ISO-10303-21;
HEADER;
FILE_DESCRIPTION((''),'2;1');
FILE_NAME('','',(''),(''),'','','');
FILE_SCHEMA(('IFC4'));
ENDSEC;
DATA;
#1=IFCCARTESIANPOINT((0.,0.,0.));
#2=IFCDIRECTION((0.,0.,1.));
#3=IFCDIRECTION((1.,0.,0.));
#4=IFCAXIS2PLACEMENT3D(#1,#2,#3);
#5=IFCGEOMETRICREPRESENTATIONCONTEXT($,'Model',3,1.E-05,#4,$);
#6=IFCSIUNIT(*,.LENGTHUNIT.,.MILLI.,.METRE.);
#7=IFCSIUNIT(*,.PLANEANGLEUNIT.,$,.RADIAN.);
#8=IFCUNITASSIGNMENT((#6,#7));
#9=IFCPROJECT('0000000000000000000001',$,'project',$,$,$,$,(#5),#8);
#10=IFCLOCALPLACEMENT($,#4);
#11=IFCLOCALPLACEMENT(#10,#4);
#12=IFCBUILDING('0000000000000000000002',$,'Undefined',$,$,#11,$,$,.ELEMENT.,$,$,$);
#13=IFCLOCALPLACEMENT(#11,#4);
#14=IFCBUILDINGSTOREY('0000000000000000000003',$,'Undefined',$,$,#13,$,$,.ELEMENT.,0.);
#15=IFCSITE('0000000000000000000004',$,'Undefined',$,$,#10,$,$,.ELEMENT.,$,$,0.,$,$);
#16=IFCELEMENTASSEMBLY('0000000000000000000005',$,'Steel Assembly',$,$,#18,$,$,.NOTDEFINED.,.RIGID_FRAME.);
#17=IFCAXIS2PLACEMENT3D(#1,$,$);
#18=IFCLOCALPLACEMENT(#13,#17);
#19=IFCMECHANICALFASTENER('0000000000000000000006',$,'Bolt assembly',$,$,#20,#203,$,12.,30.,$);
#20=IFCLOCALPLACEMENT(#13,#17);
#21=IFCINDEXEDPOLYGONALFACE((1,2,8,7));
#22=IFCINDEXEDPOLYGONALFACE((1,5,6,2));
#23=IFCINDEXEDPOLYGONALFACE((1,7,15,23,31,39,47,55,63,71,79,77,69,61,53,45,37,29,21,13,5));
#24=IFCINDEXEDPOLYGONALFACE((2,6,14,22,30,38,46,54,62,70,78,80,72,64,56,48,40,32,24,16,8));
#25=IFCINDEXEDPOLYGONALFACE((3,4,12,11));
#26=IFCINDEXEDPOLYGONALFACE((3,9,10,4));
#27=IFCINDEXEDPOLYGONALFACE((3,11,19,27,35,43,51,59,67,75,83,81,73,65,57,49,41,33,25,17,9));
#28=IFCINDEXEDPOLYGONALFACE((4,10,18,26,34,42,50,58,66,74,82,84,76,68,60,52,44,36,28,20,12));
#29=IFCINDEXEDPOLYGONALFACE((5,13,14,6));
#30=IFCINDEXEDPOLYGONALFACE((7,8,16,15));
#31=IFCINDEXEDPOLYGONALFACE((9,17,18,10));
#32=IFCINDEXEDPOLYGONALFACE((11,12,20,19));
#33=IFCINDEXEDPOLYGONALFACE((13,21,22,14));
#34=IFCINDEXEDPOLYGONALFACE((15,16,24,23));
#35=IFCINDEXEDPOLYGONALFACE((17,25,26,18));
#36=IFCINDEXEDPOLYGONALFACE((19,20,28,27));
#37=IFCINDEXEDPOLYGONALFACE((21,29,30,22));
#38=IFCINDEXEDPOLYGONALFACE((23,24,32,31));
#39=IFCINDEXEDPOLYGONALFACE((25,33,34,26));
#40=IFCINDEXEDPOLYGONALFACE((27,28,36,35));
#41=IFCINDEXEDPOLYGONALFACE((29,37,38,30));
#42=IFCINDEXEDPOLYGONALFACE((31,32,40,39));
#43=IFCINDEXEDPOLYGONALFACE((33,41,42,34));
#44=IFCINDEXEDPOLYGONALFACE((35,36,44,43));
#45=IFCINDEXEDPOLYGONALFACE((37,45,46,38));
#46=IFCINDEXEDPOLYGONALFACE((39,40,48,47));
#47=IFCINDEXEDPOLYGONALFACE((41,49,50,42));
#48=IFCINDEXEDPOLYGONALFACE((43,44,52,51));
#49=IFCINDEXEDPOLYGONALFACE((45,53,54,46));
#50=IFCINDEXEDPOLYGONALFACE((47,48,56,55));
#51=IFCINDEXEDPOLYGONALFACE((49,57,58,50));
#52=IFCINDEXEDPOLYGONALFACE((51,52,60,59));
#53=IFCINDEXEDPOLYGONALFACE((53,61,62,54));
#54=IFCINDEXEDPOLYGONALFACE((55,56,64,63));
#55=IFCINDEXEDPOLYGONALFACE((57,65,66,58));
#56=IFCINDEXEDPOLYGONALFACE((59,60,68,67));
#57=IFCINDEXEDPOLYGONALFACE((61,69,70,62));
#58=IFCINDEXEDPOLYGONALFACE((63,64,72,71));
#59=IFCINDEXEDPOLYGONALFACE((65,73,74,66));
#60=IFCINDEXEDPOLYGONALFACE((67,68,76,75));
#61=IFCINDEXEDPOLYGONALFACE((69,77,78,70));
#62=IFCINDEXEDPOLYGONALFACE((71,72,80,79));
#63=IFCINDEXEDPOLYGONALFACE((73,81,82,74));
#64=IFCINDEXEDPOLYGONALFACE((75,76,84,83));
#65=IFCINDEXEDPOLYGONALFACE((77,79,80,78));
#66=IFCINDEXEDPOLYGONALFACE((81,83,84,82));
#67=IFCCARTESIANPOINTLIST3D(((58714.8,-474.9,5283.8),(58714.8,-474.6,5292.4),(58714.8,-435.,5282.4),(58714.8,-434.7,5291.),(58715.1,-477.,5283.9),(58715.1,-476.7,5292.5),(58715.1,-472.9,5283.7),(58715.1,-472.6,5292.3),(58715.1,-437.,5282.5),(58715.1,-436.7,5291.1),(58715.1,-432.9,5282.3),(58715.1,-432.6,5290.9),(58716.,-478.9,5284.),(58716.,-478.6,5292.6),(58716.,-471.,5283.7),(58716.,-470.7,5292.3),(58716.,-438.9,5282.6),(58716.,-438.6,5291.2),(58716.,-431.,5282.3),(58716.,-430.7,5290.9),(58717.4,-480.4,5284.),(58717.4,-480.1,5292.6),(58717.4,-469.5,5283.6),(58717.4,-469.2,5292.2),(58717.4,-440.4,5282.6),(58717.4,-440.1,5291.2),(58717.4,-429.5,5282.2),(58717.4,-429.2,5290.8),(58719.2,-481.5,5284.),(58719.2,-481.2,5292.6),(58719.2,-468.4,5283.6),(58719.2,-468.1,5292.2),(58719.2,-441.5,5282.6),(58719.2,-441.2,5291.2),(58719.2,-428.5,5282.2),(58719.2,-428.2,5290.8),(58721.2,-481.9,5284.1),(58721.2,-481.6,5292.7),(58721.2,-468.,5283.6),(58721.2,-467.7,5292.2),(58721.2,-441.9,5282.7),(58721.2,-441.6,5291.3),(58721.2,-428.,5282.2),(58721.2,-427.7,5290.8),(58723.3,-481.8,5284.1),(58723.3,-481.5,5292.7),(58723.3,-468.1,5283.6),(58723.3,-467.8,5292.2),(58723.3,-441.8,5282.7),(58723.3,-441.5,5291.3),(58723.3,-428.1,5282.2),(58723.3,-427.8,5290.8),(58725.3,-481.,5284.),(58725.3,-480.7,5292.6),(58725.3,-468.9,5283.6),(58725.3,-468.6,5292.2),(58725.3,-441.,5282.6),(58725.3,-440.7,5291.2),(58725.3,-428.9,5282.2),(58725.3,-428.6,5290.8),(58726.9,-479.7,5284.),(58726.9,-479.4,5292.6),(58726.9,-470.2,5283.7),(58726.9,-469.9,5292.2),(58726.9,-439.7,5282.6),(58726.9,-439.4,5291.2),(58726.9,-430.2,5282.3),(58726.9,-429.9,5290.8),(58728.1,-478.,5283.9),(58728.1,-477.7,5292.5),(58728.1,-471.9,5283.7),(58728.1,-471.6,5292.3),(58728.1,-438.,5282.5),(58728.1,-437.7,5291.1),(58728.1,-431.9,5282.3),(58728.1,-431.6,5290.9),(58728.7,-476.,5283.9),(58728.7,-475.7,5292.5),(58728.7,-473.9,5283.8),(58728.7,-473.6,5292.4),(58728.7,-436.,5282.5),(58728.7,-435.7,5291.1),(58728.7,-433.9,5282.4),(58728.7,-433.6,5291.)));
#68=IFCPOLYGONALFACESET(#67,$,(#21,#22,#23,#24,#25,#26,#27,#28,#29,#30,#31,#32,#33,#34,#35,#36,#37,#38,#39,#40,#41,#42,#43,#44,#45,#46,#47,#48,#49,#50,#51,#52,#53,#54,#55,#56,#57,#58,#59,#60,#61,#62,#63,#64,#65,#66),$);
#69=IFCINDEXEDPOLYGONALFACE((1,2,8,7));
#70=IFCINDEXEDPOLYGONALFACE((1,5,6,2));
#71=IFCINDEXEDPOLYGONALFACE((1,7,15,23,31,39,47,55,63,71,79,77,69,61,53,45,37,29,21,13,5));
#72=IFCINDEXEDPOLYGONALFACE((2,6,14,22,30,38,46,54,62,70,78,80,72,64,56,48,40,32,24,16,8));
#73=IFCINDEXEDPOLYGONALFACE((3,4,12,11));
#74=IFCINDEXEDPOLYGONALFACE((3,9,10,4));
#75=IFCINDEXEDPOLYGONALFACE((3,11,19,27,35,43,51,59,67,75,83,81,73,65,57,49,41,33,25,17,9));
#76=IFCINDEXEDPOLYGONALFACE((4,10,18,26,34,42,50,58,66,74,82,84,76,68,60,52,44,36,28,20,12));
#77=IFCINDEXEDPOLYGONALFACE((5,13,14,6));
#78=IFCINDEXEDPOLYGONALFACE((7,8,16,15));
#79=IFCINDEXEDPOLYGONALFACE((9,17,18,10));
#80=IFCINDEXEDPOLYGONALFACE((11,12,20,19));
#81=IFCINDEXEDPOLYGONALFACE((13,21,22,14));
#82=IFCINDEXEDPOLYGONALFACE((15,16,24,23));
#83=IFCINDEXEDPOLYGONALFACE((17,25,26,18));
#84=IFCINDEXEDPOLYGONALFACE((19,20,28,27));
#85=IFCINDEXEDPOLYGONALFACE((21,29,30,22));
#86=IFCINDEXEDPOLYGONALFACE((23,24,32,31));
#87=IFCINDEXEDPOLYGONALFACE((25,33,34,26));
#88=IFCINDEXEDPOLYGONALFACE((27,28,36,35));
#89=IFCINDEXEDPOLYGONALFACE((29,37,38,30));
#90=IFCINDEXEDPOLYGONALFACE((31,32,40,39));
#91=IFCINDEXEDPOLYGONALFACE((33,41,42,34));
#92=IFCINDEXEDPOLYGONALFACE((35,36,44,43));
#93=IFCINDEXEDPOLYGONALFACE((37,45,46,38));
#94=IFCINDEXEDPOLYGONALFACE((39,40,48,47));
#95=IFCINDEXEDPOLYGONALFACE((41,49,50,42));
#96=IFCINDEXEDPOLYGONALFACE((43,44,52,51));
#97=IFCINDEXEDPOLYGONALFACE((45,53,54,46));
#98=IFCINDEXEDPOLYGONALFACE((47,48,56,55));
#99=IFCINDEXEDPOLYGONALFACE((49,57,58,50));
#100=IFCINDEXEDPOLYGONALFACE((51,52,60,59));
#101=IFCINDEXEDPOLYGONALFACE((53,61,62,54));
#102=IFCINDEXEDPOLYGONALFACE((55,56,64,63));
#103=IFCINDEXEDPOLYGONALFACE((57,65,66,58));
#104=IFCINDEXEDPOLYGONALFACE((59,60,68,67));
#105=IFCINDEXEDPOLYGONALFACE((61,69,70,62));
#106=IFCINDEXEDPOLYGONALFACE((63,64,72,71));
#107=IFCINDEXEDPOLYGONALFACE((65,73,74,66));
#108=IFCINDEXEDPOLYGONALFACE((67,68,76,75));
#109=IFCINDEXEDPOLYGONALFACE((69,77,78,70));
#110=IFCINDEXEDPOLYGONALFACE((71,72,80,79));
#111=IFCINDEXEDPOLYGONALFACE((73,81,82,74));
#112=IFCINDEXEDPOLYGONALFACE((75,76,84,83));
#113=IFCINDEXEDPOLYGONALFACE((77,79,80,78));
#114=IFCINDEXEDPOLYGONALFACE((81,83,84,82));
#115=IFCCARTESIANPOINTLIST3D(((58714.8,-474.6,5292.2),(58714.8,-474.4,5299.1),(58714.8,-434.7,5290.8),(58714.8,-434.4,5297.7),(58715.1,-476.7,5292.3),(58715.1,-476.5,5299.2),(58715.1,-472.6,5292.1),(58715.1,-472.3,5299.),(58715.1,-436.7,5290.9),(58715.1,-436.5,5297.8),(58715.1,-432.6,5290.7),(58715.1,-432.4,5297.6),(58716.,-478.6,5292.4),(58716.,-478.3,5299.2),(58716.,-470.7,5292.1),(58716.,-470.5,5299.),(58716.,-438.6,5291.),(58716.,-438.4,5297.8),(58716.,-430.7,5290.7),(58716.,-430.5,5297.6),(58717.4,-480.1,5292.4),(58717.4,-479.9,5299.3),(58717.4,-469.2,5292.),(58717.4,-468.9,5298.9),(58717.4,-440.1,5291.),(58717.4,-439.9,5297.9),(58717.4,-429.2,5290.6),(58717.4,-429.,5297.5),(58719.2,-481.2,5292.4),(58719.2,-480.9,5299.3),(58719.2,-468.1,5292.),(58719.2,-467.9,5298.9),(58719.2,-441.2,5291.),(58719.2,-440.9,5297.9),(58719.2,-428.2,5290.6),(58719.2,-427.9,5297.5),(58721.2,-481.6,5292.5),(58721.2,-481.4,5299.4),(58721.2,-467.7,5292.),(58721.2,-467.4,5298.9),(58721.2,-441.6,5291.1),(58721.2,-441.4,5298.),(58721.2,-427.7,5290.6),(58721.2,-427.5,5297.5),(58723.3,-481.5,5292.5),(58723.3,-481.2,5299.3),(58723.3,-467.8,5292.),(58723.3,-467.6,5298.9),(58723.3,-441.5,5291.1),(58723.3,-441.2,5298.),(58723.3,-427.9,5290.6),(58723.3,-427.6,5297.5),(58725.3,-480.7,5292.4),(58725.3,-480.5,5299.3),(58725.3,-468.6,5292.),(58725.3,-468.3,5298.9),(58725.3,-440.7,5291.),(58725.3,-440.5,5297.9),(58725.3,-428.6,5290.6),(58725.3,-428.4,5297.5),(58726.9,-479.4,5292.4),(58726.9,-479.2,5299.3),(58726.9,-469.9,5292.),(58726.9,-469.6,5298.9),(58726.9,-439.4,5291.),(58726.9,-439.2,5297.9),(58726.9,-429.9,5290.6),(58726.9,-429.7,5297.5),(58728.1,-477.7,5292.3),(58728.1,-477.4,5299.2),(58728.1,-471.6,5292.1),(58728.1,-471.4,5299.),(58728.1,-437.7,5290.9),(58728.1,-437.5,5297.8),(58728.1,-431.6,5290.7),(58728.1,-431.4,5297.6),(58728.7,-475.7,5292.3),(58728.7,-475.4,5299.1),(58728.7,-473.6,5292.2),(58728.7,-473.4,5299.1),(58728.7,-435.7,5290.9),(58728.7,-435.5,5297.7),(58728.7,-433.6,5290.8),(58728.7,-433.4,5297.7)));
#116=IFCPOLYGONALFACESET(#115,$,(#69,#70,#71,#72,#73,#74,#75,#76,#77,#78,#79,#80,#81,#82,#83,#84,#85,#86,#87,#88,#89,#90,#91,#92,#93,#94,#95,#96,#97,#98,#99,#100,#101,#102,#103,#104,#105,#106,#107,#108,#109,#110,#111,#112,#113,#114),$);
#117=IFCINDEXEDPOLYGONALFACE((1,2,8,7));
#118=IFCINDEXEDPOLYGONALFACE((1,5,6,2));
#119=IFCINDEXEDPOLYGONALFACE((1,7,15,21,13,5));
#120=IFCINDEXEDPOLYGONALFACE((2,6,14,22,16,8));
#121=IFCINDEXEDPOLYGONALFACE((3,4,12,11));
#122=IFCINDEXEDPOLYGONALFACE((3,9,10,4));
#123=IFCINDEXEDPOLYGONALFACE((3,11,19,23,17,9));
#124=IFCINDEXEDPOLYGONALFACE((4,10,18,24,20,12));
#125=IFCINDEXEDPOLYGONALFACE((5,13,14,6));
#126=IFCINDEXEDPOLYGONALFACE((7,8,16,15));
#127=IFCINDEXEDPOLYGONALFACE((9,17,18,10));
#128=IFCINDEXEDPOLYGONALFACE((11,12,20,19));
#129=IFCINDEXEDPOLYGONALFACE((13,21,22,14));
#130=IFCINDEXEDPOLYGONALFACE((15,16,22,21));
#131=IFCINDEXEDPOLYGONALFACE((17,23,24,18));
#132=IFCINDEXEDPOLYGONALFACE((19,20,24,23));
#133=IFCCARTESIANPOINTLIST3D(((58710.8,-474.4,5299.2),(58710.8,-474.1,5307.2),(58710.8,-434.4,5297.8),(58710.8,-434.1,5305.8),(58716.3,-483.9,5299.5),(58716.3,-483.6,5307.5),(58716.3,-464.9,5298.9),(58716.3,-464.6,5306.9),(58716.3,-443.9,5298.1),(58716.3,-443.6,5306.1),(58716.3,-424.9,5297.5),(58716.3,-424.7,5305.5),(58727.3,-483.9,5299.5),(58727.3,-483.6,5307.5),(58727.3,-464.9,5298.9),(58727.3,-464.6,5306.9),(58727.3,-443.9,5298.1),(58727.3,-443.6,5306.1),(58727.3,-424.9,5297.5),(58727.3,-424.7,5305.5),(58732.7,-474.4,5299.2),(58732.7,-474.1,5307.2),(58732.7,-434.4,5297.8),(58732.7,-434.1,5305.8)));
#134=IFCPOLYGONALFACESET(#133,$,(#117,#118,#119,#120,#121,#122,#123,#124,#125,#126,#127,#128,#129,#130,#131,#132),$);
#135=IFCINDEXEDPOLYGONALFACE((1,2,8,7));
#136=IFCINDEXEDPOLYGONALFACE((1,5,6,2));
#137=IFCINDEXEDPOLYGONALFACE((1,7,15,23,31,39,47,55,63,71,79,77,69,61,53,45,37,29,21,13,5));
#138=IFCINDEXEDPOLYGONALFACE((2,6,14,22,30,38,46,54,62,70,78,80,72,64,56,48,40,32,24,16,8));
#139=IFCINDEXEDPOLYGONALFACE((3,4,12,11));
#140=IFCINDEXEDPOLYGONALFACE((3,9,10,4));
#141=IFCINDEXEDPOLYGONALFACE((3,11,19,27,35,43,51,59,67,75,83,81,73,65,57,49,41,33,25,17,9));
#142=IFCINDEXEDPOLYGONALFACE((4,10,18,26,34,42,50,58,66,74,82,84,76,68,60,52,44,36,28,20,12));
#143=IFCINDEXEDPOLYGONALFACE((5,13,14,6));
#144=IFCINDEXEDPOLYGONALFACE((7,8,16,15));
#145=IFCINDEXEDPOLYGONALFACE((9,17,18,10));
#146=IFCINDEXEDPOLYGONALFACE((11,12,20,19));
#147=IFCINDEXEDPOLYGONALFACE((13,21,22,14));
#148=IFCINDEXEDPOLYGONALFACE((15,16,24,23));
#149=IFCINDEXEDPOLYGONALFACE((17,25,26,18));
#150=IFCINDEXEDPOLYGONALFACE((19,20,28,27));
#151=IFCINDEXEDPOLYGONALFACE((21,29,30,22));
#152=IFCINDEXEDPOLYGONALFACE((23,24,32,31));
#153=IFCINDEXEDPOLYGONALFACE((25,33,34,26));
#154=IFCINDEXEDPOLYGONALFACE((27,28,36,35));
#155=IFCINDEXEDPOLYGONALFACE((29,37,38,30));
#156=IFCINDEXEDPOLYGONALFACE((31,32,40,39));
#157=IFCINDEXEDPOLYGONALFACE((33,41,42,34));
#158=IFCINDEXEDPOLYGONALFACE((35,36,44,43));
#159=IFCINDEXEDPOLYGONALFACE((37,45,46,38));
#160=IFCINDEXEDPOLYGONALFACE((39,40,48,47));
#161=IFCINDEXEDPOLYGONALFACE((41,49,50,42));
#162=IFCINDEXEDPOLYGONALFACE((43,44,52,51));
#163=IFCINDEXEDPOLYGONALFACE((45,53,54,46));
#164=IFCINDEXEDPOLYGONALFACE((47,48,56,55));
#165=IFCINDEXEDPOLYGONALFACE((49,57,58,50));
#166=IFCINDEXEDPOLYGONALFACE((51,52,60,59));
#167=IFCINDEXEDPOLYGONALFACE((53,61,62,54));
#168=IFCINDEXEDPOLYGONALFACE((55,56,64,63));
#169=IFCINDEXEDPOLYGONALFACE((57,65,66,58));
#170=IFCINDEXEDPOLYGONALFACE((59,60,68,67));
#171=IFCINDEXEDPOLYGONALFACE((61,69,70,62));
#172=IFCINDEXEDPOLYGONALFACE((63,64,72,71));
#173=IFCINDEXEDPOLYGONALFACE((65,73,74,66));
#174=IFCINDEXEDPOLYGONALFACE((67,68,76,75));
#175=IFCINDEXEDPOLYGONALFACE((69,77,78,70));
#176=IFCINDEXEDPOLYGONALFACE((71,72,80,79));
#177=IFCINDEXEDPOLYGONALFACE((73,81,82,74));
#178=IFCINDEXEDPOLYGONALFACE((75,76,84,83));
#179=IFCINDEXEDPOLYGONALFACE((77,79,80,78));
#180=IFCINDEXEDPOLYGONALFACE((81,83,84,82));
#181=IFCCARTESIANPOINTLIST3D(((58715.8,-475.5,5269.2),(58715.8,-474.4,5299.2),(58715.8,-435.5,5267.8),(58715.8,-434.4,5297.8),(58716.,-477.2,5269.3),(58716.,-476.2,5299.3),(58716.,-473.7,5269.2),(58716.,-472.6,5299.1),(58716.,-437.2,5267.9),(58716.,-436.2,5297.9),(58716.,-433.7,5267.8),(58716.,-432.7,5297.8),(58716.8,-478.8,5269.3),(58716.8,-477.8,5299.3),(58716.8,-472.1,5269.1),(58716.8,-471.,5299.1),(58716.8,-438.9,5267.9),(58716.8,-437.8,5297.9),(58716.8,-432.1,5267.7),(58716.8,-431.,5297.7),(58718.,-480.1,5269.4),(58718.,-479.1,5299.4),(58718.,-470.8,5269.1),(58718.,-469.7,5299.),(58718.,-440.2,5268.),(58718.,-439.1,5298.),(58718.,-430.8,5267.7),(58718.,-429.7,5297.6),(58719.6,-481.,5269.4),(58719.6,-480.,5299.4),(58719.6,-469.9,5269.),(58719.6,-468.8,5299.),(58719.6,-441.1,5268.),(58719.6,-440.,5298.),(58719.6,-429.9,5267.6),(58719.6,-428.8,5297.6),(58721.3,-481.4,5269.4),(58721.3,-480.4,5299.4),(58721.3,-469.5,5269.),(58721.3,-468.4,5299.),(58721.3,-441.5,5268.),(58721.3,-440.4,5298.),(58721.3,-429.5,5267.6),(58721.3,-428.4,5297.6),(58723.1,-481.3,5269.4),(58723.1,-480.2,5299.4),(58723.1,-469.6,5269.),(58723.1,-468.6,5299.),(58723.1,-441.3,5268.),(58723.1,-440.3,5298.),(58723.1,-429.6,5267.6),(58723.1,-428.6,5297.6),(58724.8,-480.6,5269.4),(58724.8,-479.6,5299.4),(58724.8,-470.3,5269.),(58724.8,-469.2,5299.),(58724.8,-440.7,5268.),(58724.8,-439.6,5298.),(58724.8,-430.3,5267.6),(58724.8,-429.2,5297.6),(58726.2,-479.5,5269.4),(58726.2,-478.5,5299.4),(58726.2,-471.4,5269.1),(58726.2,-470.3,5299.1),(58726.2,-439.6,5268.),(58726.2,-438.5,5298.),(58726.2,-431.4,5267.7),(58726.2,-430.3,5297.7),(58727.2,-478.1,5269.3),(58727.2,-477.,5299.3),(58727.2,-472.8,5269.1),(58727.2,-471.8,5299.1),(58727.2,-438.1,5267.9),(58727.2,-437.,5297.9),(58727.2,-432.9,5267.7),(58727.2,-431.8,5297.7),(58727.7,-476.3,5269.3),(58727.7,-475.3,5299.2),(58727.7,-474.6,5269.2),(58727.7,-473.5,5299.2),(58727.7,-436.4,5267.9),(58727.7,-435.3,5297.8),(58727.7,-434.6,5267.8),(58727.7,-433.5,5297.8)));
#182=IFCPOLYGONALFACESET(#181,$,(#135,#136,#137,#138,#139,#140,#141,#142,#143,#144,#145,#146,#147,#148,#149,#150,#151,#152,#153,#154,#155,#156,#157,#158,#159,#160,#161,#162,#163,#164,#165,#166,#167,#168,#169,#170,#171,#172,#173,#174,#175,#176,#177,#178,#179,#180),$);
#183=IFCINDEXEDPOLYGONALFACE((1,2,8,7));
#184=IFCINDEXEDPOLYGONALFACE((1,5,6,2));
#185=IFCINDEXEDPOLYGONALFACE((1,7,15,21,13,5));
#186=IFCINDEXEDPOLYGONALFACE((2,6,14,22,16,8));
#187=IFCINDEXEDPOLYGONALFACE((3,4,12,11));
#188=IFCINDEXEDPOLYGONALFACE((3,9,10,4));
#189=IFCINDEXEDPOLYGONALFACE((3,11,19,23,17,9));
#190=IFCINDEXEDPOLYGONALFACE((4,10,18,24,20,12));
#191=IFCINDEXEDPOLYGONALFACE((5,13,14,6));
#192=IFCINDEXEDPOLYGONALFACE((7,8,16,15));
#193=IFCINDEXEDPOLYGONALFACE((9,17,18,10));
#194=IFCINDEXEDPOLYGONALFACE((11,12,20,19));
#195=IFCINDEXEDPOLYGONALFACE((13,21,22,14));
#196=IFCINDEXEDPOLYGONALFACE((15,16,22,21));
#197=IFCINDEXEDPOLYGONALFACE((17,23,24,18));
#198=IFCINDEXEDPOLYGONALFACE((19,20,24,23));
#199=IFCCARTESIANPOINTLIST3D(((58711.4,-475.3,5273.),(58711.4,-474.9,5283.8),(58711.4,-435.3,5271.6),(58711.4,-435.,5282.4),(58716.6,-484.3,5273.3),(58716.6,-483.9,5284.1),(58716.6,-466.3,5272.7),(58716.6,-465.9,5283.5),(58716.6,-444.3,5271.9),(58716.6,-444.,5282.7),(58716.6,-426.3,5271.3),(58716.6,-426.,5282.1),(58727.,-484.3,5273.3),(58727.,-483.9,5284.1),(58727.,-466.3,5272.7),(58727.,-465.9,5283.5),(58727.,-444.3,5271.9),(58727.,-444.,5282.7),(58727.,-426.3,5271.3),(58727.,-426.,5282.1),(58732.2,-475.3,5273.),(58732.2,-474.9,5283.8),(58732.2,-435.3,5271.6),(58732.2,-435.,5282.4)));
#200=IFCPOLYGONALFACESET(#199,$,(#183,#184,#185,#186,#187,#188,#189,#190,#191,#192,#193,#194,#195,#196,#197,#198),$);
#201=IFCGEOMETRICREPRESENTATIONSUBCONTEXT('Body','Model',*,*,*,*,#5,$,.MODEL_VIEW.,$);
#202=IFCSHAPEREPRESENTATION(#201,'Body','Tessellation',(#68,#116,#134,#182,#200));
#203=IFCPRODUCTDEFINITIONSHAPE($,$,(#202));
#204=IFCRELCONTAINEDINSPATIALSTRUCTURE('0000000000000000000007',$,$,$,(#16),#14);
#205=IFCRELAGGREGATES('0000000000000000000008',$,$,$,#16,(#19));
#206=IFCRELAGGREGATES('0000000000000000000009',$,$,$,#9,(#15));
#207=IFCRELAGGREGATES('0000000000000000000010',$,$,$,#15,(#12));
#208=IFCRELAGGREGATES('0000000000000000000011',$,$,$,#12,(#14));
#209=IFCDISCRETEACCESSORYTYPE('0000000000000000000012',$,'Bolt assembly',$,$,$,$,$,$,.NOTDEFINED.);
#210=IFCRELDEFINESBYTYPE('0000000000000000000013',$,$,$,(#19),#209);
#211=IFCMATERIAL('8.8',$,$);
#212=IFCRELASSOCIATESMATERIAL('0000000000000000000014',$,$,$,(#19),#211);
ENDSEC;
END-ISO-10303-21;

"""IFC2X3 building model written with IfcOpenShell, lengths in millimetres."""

from ifc_helpers import new_model, si_unit, frame, origin_with_axes, origin_2d_with_axis, place, context, subcontext, project, spatial, polyline, circle, outline, extrude, source, transform, mapped, material, type_object, element, aggregate, save


model = new_model("IFC2X3")

# Units and contexts
model_context = context("Model", 3, precision=1e-05, world=origin_with_axes())
body_context = subcontext(model_context, "Body", "Model", "MODEL_VIEW")
ifc_project = project(units=[si_unit("LENGTHUNIT", "METRE", prefix="MILLI"), si_unit("PLANEANGLEUNIT", "RADIAN")], contexts=[model_context])

# Site, building, storey
site_placement = place(None, origin_with_axes())
site = spatial("IfcSite", under=ifc_project, at=site_placement, Name="Undefined", CompositionType="ELEMENT", RefElevation=0.0)
building_placement = place(site_placement, origin_with_axes())
building = spatial("IfcBuilding", under=site, at=building_placement, Name="Undefined", CompositionType="ELEMENT")
storey_placement = place(building_placement, origin_with_axes())
storey = spatial("IfcBuildingStorey", under=building, at=storey_placement, Name="Undefined", CompositionType="ELEMENT", Elevation=0.0)

# Shared definitions
discrete_accessory_type_1 = type_object("IfcDiscreteAccessoryType", Name="Bolt assembly")

# Element assembly, mechanical fastener
assembly_1_placement = place(storey_placement, origin_with_axes())
assembly_1 = element("IfcElementAssembly", 1, at=assembly_1_placement, inside=storey, Name="Steel Assembly", AssemblyPlace="NOTDEFINED", PredefinedType="RIGID_FRAME")
ifc_material_1 = material(Name="8.8")
shared_shape_1 = source(origin_with_axes(), body_context, "Body", "SweptSolid", [
    extrude(circle(Radius=7.0, at=origin_2d_with_axis()), frame((0.0, -0.1, 0.0), z_axis=(0.0, 1.0, 0.0), x_axis=(1.0, 0.0, 0.0)), (0.0, 0.0, 1.0), 8.6),
    extrude(circle(Radius=7.0, at=origin_2d_with_axis()), frame((0.0, -6.8, 0.0), z_axis=(0.0, 1.0, 0.0), x_axis=(1.0, 0.0, 0.0)), (0.0, 0.0, 1.0), 6.9),
    extrude(outline(polyline([(11.0, 0.0), (5.5, 9.5), (-5.5, 9.5), (-11.0, 0.0), (-5.5, -9.5), (5.5, -9.5), (11.0, 0.0)])), frame((0.0, -14.9, 0.0), z_axis=(0.0, 1.0, 0.0), x_axis=(1.0, 0.0, 0.0)), (0.0, 0.0, 1.0), 8.0),
    extrude(circle(Radius=6.0, at=origin_2d_with_axis()), frame((0.0, -6.9, 0.0), z_axis=(0.0, 1.0, 0.0), x_axis=(1.0, 0.0, 0.0)), (0.0, 0.0, 1.0), 30.0),
    extrude(outline(polyline([(10.4, 0.0), (5.2, 9.0), (-5.2, 9.0), (-10.4, 0.0), (-5.2, -9.0), (5.2, -9.0), (10.4, 0.0)])), frame((0.0, 8.5, 0.0), z_axis=(0.0, 1.0, 0.0), x_axis=(1.0, 0.0, 0.0)), (0.0, 0.0, 1.0), 10.8),
])
mechanical_fastener_1_placement = place(assembly_1_placement, frame((58721.8, -454.7, 5291.6), z_axis=(-0.000003, -0.999388, 0.034975), x_axis=(-1.0, 0.000003, 0.0)))
mechanical_fastener_1 = element("IfcMechanicalFastener", 2, at=mechanical_fastener_1_placement, type_object=discrete_accessory_type_1, material=ifc_material_1, Name="Bolt assembly", NominalDiameter=12.0, NominalLength=30.0, context=body_context, shape_type="MappedRepresentation", body=[
    mapped(shared_shape_1, transform((0.0, 0.0, -20.0))),
    mapped(shared_shape_1, transform((0.0, 0.0, 20.0))),
])
aggregate(assembly_1, [mechanical_fastener_1])

save(model, "model.ifc")
